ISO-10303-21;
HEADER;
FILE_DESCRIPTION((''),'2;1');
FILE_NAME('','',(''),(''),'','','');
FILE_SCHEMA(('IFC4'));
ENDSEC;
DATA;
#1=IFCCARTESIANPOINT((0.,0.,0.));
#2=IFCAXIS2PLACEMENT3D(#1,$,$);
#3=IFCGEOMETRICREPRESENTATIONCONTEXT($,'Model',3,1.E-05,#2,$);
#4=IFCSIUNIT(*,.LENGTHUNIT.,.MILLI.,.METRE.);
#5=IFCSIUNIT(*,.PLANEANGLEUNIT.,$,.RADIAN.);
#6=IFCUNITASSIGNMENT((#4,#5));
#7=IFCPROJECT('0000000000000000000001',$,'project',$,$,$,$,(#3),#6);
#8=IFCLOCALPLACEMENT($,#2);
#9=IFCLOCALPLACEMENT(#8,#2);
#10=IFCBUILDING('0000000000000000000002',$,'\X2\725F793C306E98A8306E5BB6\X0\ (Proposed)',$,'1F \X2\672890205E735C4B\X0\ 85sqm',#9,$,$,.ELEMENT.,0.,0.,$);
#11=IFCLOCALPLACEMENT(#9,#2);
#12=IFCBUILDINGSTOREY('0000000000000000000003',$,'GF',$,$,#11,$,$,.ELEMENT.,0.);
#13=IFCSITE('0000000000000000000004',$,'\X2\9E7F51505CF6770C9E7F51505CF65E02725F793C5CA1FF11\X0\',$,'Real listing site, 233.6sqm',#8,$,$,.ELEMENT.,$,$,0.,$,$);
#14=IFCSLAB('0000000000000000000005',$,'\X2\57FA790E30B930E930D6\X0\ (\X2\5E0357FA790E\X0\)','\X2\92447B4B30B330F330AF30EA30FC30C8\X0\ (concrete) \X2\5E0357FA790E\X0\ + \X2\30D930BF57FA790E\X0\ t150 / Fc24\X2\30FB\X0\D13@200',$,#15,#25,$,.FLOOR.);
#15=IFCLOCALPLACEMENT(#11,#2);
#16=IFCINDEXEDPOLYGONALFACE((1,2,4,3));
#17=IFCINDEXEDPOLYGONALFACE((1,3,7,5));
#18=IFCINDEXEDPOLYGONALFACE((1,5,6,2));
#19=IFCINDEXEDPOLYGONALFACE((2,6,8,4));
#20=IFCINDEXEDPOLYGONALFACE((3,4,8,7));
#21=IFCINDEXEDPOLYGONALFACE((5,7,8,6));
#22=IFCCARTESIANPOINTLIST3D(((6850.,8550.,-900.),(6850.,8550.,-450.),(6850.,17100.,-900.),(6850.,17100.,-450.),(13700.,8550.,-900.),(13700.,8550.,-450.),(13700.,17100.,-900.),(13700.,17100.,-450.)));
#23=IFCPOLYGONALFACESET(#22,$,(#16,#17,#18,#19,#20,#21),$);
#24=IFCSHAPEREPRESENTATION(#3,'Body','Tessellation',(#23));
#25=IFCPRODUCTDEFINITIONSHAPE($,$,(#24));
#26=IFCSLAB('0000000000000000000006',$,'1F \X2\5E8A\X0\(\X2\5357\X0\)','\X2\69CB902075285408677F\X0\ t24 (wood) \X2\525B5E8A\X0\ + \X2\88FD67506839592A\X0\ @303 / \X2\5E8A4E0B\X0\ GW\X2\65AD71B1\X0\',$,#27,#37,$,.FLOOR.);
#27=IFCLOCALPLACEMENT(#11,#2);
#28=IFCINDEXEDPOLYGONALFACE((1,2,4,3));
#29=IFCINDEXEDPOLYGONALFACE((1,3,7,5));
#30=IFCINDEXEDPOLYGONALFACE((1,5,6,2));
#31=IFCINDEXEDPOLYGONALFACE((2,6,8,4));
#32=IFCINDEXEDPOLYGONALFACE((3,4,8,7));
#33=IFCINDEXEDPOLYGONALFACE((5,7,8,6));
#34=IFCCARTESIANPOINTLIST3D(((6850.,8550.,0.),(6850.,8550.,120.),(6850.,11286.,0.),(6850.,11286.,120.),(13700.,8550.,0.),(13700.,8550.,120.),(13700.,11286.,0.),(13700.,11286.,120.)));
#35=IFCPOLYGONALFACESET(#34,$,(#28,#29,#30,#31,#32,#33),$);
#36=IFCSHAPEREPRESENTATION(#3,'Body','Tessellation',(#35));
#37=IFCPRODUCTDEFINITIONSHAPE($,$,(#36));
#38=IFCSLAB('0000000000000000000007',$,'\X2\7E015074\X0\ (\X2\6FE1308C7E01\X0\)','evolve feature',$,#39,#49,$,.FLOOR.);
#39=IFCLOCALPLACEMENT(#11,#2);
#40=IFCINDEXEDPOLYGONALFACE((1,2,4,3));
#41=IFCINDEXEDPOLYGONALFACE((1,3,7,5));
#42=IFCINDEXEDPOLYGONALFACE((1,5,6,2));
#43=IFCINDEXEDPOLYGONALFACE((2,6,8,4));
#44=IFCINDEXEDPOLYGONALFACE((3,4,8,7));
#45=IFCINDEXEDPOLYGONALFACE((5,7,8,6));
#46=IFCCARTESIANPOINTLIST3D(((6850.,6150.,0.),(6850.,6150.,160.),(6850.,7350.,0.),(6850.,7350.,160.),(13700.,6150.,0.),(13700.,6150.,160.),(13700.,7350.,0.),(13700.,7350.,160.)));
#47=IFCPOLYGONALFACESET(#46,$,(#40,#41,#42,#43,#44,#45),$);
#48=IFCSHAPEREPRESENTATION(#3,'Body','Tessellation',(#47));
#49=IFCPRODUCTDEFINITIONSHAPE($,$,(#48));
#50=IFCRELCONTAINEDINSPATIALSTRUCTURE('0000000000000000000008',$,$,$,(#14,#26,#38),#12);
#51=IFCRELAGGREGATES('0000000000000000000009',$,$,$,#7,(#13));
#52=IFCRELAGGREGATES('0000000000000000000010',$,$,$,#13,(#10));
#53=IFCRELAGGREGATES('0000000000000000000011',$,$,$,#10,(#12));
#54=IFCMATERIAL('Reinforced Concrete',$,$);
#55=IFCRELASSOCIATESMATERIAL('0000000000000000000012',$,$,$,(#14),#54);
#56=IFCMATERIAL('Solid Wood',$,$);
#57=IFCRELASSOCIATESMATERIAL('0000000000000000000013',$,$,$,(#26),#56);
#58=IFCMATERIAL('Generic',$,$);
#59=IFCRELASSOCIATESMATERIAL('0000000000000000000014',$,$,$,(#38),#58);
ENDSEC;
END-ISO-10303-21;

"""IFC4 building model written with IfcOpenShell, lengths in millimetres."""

from ifc_helpers import new_model, si_unit, frame, frame_2d, origin, place, context, project, spatial, rectangle, extrude, material, element, save


model = new_model("IFC4")

# Units and contexts
model_context = context("Model", 3, precision=1e-05, world=origin())
ifc_project = project(units=[si_unit("LENGTHUNIT", "METRE", prefix="MILLI"), si_unit("PLANEANGLEUNIT", "RADIAN")], contexts=[model_context])

# Site, building, storey
site_placement = place(None, origin())
site = spatial("IfcSite", under=ifc_project, at=site_placement, Name="鹿児島県鹿児島市牟礼岡１", ObjectType="Real listing site, 233.6sqm", CompositionType="ELEMENT", RefElevation=0.0)
building_placement = place(site_placement, origin())
building = spatial("IfcBuilding", under=site, at=building_placement, Name="牟礼の風の家 (Proposed)", ObjectType="1F 木造平屋 85sqm", CompositionType="ELEMENT", ElevationOfRefHeight=0.0, ElevationOfTerrain=0.0)
storey_placement = place(building_placement, origin())
storey = spatial("IfcBuildingStorey", under=building, at=storey_placement, Name="GF", CompositionType="ELEMENT", Elevation=0.0)

# Slabs
ifc_material_1 = material(Name="Reinforced Concrete")
slab_1_placement = place(storey_placement, frame((3425.0, 4275.0, -450.0)))
element("IfcSlab", 1, at=slab_1_placement, inside=storey, material=ifc_material_1, Name="基礎スラブ (布基礎)", Description="鉄筋コンクリート (concrete) 布基礎 + ベタ基礎 t150 / Fc24・D13@200", PredefinedType="FLOOR", context=model_context, shape_type="SweptSolid", body=[
    extrude(rectangle(XDim=6850.0, YDim=8550.0, at=frame_2d((3425.0, 4275.0))), frame((3425.0, 4275.0, -450.0)), (0.0, 0.0, 1.0), 450.0),
])
ifc_material_2 = material(Name="Solid Wood")
slab_2_placement = place(storey_placement, frame((3425.0, 4275.0, 0.0)))
element("IfcSlab", 2, at=slab_2_placement, inside=storey, material=ifc_material_2, Name="1F 床(南)", Description="構造用合板 t24 (wood) 剛床 + 製材根太 @303 / 床下 GW断熱", PredefinedType="FLOOR", context=model_context, shape_type="SweptSolid", body=[
    extrude(rectangle(XDim=6850.0, YDim=2736.0, at=frame_2d((3425.0, 1368.0))), frame((3425.0, 4275.0, 0.0)), (0.0, 0.0, 1.0), 120.0),
])
ifc_material_3 = material(Name="Generic")
slab_3_placement = place(storey_placement, frame((3425.0, 3075.0, 0.0)))
element("IfcSlab", 3, at=slab_3_placement, inside=storey, material=ifc_material_3, Name="縁側 (濡れ縁)", Description="evolve feature", PredefinedType="FLOOR", context=model_context, shape_type="SweptSolid", body=[
    extrude(rectangle(XDim=6850.0, YDim=1200.0, at=frame_2d((3425.0, 600.0))), frame((3425.0, 3075.0, 0.0)), (0.0, 0.0, 1.0), 160.0),
])

save(model, "model.ifc")
